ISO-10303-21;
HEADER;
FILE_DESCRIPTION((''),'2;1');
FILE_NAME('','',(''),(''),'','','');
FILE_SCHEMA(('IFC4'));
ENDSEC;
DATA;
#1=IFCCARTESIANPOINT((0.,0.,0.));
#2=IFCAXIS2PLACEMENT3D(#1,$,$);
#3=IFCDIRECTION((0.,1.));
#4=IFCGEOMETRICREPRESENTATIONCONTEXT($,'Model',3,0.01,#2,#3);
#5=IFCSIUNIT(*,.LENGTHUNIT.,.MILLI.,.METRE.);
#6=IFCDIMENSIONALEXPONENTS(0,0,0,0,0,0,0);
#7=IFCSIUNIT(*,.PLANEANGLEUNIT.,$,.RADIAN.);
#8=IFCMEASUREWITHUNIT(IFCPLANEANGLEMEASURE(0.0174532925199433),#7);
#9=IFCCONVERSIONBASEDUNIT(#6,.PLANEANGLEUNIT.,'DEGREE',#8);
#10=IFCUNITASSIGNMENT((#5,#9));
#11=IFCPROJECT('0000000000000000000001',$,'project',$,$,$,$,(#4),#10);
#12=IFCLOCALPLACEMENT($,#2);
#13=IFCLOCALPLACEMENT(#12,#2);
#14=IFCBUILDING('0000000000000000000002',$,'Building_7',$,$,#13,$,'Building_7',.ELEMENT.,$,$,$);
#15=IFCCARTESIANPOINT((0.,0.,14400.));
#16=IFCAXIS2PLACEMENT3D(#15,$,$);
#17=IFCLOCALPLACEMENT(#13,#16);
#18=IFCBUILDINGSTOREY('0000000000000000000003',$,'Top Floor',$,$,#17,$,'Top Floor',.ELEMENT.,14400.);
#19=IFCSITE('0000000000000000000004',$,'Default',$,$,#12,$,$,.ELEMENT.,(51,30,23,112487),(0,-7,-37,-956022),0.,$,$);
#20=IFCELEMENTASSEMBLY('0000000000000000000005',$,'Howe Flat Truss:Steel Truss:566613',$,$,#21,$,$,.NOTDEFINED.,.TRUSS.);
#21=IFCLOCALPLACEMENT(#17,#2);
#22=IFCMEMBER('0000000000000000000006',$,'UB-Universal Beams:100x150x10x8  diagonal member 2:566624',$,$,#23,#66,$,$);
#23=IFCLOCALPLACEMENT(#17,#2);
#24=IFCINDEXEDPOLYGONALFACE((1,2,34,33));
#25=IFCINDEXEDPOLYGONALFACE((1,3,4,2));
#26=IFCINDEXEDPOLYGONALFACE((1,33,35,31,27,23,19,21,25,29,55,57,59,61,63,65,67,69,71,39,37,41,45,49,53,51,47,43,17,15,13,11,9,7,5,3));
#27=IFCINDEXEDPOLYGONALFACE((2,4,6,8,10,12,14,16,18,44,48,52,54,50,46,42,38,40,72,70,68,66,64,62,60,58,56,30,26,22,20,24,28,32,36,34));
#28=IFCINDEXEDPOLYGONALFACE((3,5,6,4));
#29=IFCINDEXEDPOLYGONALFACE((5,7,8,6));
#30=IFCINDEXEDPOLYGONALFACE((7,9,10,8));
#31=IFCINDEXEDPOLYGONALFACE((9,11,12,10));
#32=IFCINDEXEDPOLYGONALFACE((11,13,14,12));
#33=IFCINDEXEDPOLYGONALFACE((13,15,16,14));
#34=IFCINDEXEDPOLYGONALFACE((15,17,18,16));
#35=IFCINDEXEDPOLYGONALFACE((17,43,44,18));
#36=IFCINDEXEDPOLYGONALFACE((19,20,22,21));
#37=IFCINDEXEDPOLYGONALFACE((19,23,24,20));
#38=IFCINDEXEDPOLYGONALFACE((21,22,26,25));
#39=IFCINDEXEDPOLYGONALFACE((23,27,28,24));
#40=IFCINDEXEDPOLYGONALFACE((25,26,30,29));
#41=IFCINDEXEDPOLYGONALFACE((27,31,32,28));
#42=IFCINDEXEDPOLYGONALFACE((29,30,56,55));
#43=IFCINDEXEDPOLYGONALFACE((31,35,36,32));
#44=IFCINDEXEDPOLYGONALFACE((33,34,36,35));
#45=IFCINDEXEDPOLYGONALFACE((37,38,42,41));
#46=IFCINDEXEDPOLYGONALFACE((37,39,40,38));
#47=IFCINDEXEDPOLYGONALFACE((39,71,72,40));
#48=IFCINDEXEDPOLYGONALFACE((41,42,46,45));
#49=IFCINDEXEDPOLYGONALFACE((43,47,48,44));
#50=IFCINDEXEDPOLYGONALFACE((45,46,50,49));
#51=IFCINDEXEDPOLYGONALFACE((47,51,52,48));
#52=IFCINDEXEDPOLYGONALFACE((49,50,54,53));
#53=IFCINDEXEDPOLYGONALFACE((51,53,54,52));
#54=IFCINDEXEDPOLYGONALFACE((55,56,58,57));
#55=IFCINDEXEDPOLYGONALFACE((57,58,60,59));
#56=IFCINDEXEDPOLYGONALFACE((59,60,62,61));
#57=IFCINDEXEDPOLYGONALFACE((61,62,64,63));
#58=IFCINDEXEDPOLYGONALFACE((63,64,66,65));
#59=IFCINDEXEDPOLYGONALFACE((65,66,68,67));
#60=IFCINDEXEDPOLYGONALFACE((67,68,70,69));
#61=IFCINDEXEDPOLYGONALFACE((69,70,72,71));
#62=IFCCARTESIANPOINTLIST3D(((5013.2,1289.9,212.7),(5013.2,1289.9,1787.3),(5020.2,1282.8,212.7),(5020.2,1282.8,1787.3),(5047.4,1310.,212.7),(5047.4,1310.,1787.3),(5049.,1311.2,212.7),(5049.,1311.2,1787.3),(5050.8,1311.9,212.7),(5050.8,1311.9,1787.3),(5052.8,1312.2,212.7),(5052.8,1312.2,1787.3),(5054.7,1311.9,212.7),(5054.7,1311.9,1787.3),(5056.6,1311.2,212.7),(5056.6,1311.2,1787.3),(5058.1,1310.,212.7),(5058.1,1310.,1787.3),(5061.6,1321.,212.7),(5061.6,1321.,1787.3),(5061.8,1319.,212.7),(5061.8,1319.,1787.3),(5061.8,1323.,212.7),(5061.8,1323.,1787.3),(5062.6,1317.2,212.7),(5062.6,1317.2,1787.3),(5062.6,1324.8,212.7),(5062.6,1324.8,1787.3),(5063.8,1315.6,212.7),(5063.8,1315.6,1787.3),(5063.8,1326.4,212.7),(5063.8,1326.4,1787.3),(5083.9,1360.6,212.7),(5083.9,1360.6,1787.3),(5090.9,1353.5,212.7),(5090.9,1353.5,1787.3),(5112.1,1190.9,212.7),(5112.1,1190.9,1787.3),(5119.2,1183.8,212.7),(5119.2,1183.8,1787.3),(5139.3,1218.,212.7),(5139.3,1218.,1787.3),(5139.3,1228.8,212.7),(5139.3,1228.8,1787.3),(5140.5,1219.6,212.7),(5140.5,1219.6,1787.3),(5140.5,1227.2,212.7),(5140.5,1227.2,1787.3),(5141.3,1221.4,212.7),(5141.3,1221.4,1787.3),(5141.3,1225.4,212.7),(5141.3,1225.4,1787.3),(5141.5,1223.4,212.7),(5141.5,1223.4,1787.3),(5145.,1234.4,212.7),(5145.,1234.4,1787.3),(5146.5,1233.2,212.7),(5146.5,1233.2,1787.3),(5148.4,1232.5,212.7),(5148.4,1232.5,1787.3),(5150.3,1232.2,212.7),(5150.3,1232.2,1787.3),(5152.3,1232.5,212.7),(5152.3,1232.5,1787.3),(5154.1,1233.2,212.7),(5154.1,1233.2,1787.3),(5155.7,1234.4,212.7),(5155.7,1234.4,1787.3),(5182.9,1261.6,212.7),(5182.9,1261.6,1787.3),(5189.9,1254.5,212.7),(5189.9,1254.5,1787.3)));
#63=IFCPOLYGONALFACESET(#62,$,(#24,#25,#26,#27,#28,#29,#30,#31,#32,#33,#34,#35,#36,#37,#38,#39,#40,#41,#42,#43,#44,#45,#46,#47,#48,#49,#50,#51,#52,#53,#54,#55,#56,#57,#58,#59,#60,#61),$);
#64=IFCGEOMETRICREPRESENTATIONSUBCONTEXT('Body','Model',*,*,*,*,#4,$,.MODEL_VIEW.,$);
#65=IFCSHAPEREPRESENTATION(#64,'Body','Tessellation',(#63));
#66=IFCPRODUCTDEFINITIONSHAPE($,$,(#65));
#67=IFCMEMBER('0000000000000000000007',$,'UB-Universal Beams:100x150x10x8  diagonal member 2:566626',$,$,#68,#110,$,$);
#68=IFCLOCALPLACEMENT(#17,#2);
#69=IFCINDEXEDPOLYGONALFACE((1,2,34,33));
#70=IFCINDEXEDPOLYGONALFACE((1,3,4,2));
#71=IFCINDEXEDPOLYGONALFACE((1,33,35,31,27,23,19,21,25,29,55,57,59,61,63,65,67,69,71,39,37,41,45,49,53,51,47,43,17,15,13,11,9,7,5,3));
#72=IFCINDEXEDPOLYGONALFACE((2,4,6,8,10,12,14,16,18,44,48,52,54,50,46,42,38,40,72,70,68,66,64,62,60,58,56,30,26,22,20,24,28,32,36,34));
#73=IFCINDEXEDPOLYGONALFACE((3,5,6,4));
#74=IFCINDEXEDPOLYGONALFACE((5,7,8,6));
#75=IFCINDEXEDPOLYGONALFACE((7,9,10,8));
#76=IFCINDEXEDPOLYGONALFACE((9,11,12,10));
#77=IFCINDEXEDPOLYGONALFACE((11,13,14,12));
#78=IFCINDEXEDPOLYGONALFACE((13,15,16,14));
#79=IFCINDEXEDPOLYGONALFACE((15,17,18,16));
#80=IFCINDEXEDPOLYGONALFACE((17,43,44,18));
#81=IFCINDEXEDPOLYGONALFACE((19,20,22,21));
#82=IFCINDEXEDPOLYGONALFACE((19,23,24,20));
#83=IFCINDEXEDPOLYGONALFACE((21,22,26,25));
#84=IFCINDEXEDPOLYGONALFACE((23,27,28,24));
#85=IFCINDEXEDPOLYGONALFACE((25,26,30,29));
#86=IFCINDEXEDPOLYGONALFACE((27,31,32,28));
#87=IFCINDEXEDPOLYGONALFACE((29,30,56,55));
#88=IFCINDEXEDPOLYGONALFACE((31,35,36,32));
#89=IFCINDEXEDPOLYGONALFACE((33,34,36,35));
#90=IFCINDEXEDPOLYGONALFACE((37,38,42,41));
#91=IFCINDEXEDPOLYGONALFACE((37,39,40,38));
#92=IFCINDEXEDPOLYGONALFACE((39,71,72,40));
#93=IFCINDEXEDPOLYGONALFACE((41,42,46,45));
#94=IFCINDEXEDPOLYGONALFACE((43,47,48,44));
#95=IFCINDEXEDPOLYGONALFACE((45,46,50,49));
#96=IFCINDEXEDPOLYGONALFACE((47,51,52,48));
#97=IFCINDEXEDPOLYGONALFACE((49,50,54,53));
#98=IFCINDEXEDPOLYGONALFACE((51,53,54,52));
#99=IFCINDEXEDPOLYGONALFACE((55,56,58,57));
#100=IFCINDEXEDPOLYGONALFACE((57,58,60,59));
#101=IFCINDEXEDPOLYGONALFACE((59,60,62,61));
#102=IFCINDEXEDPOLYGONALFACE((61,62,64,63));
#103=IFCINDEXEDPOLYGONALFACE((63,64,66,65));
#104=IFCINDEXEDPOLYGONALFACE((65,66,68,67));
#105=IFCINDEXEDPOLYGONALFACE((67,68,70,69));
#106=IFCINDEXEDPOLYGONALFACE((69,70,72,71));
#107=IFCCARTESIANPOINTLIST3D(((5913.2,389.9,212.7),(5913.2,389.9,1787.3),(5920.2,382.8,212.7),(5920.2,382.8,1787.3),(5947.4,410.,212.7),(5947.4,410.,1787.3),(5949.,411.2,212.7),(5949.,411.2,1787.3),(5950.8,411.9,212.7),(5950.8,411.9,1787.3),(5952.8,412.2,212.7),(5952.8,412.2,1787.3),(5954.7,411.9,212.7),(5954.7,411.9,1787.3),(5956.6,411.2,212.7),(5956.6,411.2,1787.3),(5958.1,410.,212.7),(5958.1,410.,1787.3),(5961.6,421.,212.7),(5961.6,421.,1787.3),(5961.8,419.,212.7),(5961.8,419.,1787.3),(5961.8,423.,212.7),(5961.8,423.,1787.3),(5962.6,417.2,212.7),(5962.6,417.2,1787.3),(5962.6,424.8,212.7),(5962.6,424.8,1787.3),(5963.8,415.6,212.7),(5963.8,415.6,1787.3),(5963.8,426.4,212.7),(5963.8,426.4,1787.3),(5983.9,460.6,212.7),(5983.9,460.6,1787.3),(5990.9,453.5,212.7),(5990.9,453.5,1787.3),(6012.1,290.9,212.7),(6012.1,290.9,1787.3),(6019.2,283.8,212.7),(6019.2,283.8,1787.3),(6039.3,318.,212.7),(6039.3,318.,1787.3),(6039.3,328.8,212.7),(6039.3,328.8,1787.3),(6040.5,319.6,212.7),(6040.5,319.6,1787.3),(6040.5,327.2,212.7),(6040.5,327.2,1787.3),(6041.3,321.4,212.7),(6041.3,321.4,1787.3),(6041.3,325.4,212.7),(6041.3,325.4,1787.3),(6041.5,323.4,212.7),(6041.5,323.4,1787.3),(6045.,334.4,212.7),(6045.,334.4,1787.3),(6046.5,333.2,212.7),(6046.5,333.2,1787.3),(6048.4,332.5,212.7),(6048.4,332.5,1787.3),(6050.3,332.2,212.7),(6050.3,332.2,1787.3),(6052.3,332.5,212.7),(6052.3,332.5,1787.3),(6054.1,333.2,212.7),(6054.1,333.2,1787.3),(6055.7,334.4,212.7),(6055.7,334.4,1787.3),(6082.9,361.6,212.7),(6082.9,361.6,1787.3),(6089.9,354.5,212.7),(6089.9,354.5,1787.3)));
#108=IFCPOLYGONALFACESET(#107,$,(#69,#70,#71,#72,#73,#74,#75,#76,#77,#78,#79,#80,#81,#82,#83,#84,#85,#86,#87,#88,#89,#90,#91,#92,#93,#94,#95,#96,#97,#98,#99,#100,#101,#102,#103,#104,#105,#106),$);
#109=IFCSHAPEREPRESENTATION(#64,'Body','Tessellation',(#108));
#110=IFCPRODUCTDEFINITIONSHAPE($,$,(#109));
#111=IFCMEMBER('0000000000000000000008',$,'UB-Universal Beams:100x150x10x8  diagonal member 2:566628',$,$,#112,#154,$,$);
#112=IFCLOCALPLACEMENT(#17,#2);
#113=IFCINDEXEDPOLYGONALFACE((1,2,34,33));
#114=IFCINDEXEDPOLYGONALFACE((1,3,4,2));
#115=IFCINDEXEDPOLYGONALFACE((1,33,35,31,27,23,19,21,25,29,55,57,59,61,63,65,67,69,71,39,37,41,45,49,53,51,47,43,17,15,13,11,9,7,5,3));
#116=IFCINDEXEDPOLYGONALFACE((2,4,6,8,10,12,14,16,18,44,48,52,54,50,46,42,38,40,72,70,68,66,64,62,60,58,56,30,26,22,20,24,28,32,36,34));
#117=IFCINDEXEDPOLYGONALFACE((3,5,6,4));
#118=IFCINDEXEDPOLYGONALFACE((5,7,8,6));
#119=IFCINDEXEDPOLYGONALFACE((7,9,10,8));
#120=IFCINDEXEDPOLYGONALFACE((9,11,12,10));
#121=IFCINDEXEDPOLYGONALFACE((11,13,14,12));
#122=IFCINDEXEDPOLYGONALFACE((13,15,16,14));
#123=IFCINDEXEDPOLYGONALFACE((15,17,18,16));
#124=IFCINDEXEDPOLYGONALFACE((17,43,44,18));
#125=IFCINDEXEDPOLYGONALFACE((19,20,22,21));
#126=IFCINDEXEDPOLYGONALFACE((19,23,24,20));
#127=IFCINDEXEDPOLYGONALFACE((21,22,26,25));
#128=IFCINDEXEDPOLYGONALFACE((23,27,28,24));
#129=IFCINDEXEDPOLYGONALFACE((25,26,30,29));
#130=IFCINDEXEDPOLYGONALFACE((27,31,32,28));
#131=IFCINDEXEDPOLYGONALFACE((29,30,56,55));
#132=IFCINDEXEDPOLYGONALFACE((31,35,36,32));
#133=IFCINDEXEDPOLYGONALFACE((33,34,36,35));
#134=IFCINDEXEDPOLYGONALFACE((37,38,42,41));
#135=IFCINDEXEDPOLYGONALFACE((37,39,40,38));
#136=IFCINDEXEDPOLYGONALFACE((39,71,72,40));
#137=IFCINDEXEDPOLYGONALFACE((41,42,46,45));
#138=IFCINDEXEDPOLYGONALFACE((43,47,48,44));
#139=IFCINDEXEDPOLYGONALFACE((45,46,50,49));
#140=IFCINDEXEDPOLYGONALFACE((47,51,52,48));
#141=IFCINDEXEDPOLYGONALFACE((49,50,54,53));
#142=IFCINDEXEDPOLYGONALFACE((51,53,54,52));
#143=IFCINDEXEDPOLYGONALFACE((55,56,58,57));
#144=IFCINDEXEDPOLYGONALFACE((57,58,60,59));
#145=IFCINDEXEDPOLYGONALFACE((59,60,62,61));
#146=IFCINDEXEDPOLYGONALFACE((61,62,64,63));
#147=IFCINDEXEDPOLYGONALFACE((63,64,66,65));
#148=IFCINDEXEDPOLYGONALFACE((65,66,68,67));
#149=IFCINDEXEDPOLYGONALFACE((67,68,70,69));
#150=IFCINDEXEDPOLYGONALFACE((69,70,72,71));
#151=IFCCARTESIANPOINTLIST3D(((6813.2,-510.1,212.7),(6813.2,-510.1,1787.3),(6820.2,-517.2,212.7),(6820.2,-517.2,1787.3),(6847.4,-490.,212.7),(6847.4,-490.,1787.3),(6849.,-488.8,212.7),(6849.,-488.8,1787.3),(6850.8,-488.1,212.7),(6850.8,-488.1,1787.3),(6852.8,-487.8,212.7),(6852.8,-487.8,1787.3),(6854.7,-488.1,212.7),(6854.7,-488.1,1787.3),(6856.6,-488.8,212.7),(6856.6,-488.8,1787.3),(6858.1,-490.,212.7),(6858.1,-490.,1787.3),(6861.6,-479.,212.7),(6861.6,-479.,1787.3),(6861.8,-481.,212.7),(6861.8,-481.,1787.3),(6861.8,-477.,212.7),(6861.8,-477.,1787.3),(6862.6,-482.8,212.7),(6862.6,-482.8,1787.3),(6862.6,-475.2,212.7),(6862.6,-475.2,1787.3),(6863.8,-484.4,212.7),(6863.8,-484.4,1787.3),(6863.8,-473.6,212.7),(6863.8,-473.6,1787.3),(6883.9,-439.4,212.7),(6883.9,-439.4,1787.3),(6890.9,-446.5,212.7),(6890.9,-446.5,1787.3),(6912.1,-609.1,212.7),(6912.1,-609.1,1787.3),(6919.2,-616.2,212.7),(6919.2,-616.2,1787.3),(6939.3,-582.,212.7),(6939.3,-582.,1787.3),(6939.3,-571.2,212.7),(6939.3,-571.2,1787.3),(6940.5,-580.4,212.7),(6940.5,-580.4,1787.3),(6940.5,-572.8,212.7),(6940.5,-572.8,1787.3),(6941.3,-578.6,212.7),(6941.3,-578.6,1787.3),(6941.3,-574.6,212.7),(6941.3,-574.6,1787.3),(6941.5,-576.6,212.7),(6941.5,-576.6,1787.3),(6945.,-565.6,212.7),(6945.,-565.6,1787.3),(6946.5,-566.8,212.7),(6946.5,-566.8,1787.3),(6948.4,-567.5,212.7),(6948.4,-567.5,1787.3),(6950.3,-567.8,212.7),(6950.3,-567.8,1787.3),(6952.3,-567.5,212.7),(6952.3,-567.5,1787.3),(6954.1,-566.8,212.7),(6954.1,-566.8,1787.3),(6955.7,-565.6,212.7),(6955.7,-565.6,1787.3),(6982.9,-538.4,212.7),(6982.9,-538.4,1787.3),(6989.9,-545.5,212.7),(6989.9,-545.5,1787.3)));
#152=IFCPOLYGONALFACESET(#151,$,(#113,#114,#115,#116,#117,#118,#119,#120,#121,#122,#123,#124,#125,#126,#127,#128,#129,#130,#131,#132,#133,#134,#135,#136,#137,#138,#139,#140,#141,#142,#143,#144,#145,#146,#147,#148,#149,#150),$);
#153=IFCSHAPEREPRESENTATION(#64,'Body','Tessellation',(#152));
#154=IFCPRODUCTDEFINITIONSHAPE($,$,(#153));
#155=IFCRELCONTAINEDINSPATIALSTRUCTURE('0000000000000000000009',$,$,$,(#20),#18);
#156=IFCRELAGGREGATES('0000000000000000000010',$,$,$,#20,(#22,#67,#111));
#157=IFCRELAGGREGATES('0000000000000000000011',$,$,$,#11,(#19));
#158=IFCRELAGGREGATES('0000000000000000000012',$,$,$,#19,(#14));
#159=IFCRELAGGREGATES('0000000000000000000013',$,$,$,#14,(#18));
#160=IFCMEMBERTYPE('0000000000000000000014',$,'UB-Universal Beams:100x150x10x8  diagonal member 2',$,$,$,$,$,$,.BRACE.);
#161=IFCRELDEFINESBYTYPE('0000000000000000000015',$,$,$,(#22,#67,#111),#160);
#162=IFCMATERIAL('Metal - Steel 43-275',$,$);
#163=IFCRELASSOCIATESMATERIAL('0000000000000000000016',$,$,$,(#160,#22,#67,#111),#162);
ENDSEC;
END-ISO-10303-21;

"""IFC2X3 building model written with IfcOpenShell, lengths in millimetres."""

from ifc_helpers import new_model, entity, si_unit, converted_unit, direction, frame, frame_2d, origin, place, context, subcontext, project, spatial, polyline, circle_curve, parameter, trimmed, segment, composite_curve, outline, extrude, source, transform, mapped, material, type_object, type_shapes, element, aggregate, save


model = new_model("IFC2X3")

# Units and contexts
model_context = context("Model", 3, precision=0.01, world=origin(), true_north=direction((0.0, 1.0)))
body_context = subcontext(model_context, "Body", "Model", "MODEL_VIEW")
ifc_project = project(units=[si_unit("LENGTHUNIT", "METRE", prefix="MILLI"), converted_unit("PLANEANGLEUNIT", "DEGREE", entity("IfcPlaneAngleMeasure", 0.0174532925199433), si_unit("PLANEANGLEUNIT", "RADIAN"), dimensions=[0, 0, 0, 0, 0, 0, 0])], contexts=[model_context])

# Site, building, storey
site_placement = place(None, origin())
site = spatial("IfcSite", under=ifc_project, at=site_placement, Name="Default", CompositionType="ELEMENT", RefLatitude=(51, 30, 23, 112487), RefLongitude=(0, -7, -37, -956022), RefElevation=0.0)
building_placement = place(site_placement, origin())
building = spatial("IfcBuilding", under=site, at=building_placement, Name="Building_7", LongName="Building_7", CompositionType="ELEMENT")
storey_placement = place(building_placement, frame((0.0, 0.0, 14400.0)))
storey = spatial("IfcBuildingStorey", under=building, at=storey_placement, Name="Top Floor", LongName="Top Floor", CompositionType="ELEMENT", Elevation=14400.0)

# Shared definitions
ifc_material = material(Name="Metal - Steel 43-275")

# Shared definitions
member_type_1 = type_object("IfcMemberType", Name="UB-Universal Beams:100x150x10x8  diagonal member 2", PredefinedType="BRACE", material=ifc_material)
shared_shape_1 = source(origin(), body_context, "Body", "SweptSolid", [
    extrude(outline(composite_curve([segment(polyline([(-50.0, -65.0), (-50.0, -75.0)]), True, "CONTINUOUS"), segment(polyline([(-50.0, -75.0), (50.0, -75.0)]), True, "CONTINUOUS"), segment(polyline([(50.0, -75.0), (50.0, -65.0)]), True, "CONTINUOUS"), segment(polyline([(50.0, -65.0), (11.6, -65.0)]), True, "CONTINUOUS"), segment(trimmed(circle_curve(frame_2d((11.6, -57.4), x_axis=(1.0, 0.0)), 7.6), [parameter(180.0)], [parameter(270.0)], True, "PARAMETER"), False, "CONTINUOUS"), segment(polyline([(4.0, -57.4), (4.0, 57.4)]), True, "CONTINUOUS"), segment(trimmed(circle_curve(frame_2d((11.6, 57.4), x_axis=(1.0, 0.0)), 7.6), [parameter(90.0)], [parameter(180.0)], True, "PARAMETER"), False, "CONTINUOUS"), segment(polyline([(11.6, 65.0), (50.0, 65.0)]), True, "CONTINUOUS"), segment(polyline([(50.0, 65.0), (50.0, 75.0)]), True, "CONTINUOUS"), segment(polyline([(50.0, 75.0), (-50.0, 75.0)]), True, "CONTINUOUS"), segment(polyline([(-50.0, 75.0), (-50.0, 65.0)]), True, "CONTINUOUS"), segment(polyline([(-50.0, 65.0), (-11.6, 65.0)]), True, "CONTINUOUS"), segment(trimmed(circle_curve(frame_2d((-11.6, 57.4), x_axis=(1.0, 0.0)), 7.6), [parameter(360.0)], [parameter(90.0)], True, "PARAMETER"), False, "CONTINUOUS"), segment(polyline([(-4.0, 57.4), (-4.0, -57.4)]), True, "CONTINUOUS"), segment(trimmed(circle_curve(frame_2d((-11.6, -57.4), x_axis=(1.0, 0.0)), 7.6), [parameter(270.0)], [parameter(360.0)], True, "PARAMETER"), False, "CONTINUOUS"), segment(polyline([(-11.6, -65.0), (-50.0, -65.0)]), True, "CONTINUOUS")], self_intersect=False)), frame((-787.3, 0.0, 0.0), z_axis=(-1.0, 0.0, 0.0), x_axis=(0.0, -1.0, 0.0)), (0.0, 0.0, -1.0), 1574.6),
])
type_shapes(member_type_1, [shared_shape_1])

# Element assembly, members
assembly_1_placement = place(storey_placement, origin())
assembly_1 = element("IfcElementAssembly", 1, at=assembly_1_placement, inside=storey, Name="Howe Flat Truss:Steel Truss:566613", AssemblyPlace="NOTDEFINED", PredefinedType="TRUSS")
member_1_placement = place(assembly_1_placement, frame((5101.5, 1272.2, 1000.0), z_axis=(0.707107, -0.707107, 0.0), x_axis=(0.0, 0.0, 1.0)))
member_1 = element("IfcMember", 2, at=member_1_placement, type_object=member_type_1, material=ifc_material, Name="UB-Universal Beams:100x150x10x8  diagonal member 2:566624", context=body_context, shape_type="MappedRepresentation", body=[
    mapped(shared_shape_1, transform((0.0, 0.0, 0.0), scale=1.0)),
])
member_2_placement = place(assembly_1_placement, frame((6001.5, 372.2, 1000.0), z_axis=(0.707107, -0.707107, 0.0), x_axis=(0.0, 0.0, 1.0)))
member_2 = element("IfcMember", 3, at=member_2_placement, type_object=member_type_1, material=ifc_material, Name="UB-Universal Beams:100x150x10x8  diagonal member 2:566626", context=body_context, shape_type="MappedRepresentation", body=[
    mapped(shared_shape_1, transform((0.0, 0.0, 0.0), scale=1.0)),
])
member_3_placement = place(assembly_1_placement, frame((6901.5, -527.8, 1000.0), z_axis=(0.707107, -0.707107, 0.0), x_axis=(0.0, 0.0, 1.0)))
member_3 = element("IfcMember", 4, at=member_3_placement, type_object=member_type_1, material=ifc_material, Name="UB-Universal Beams:100x150x10x8  diagonal member 2:566628", context=body_context, shape_type="MappedRepresentation", body=[
    mapped(shared_shape_1, transform((0.0, 0.0, 0.0), scale=1.0)),
])

aggregate(assembly_1, [member_1, member_2, member_3])

save(model, "model.ifc")
